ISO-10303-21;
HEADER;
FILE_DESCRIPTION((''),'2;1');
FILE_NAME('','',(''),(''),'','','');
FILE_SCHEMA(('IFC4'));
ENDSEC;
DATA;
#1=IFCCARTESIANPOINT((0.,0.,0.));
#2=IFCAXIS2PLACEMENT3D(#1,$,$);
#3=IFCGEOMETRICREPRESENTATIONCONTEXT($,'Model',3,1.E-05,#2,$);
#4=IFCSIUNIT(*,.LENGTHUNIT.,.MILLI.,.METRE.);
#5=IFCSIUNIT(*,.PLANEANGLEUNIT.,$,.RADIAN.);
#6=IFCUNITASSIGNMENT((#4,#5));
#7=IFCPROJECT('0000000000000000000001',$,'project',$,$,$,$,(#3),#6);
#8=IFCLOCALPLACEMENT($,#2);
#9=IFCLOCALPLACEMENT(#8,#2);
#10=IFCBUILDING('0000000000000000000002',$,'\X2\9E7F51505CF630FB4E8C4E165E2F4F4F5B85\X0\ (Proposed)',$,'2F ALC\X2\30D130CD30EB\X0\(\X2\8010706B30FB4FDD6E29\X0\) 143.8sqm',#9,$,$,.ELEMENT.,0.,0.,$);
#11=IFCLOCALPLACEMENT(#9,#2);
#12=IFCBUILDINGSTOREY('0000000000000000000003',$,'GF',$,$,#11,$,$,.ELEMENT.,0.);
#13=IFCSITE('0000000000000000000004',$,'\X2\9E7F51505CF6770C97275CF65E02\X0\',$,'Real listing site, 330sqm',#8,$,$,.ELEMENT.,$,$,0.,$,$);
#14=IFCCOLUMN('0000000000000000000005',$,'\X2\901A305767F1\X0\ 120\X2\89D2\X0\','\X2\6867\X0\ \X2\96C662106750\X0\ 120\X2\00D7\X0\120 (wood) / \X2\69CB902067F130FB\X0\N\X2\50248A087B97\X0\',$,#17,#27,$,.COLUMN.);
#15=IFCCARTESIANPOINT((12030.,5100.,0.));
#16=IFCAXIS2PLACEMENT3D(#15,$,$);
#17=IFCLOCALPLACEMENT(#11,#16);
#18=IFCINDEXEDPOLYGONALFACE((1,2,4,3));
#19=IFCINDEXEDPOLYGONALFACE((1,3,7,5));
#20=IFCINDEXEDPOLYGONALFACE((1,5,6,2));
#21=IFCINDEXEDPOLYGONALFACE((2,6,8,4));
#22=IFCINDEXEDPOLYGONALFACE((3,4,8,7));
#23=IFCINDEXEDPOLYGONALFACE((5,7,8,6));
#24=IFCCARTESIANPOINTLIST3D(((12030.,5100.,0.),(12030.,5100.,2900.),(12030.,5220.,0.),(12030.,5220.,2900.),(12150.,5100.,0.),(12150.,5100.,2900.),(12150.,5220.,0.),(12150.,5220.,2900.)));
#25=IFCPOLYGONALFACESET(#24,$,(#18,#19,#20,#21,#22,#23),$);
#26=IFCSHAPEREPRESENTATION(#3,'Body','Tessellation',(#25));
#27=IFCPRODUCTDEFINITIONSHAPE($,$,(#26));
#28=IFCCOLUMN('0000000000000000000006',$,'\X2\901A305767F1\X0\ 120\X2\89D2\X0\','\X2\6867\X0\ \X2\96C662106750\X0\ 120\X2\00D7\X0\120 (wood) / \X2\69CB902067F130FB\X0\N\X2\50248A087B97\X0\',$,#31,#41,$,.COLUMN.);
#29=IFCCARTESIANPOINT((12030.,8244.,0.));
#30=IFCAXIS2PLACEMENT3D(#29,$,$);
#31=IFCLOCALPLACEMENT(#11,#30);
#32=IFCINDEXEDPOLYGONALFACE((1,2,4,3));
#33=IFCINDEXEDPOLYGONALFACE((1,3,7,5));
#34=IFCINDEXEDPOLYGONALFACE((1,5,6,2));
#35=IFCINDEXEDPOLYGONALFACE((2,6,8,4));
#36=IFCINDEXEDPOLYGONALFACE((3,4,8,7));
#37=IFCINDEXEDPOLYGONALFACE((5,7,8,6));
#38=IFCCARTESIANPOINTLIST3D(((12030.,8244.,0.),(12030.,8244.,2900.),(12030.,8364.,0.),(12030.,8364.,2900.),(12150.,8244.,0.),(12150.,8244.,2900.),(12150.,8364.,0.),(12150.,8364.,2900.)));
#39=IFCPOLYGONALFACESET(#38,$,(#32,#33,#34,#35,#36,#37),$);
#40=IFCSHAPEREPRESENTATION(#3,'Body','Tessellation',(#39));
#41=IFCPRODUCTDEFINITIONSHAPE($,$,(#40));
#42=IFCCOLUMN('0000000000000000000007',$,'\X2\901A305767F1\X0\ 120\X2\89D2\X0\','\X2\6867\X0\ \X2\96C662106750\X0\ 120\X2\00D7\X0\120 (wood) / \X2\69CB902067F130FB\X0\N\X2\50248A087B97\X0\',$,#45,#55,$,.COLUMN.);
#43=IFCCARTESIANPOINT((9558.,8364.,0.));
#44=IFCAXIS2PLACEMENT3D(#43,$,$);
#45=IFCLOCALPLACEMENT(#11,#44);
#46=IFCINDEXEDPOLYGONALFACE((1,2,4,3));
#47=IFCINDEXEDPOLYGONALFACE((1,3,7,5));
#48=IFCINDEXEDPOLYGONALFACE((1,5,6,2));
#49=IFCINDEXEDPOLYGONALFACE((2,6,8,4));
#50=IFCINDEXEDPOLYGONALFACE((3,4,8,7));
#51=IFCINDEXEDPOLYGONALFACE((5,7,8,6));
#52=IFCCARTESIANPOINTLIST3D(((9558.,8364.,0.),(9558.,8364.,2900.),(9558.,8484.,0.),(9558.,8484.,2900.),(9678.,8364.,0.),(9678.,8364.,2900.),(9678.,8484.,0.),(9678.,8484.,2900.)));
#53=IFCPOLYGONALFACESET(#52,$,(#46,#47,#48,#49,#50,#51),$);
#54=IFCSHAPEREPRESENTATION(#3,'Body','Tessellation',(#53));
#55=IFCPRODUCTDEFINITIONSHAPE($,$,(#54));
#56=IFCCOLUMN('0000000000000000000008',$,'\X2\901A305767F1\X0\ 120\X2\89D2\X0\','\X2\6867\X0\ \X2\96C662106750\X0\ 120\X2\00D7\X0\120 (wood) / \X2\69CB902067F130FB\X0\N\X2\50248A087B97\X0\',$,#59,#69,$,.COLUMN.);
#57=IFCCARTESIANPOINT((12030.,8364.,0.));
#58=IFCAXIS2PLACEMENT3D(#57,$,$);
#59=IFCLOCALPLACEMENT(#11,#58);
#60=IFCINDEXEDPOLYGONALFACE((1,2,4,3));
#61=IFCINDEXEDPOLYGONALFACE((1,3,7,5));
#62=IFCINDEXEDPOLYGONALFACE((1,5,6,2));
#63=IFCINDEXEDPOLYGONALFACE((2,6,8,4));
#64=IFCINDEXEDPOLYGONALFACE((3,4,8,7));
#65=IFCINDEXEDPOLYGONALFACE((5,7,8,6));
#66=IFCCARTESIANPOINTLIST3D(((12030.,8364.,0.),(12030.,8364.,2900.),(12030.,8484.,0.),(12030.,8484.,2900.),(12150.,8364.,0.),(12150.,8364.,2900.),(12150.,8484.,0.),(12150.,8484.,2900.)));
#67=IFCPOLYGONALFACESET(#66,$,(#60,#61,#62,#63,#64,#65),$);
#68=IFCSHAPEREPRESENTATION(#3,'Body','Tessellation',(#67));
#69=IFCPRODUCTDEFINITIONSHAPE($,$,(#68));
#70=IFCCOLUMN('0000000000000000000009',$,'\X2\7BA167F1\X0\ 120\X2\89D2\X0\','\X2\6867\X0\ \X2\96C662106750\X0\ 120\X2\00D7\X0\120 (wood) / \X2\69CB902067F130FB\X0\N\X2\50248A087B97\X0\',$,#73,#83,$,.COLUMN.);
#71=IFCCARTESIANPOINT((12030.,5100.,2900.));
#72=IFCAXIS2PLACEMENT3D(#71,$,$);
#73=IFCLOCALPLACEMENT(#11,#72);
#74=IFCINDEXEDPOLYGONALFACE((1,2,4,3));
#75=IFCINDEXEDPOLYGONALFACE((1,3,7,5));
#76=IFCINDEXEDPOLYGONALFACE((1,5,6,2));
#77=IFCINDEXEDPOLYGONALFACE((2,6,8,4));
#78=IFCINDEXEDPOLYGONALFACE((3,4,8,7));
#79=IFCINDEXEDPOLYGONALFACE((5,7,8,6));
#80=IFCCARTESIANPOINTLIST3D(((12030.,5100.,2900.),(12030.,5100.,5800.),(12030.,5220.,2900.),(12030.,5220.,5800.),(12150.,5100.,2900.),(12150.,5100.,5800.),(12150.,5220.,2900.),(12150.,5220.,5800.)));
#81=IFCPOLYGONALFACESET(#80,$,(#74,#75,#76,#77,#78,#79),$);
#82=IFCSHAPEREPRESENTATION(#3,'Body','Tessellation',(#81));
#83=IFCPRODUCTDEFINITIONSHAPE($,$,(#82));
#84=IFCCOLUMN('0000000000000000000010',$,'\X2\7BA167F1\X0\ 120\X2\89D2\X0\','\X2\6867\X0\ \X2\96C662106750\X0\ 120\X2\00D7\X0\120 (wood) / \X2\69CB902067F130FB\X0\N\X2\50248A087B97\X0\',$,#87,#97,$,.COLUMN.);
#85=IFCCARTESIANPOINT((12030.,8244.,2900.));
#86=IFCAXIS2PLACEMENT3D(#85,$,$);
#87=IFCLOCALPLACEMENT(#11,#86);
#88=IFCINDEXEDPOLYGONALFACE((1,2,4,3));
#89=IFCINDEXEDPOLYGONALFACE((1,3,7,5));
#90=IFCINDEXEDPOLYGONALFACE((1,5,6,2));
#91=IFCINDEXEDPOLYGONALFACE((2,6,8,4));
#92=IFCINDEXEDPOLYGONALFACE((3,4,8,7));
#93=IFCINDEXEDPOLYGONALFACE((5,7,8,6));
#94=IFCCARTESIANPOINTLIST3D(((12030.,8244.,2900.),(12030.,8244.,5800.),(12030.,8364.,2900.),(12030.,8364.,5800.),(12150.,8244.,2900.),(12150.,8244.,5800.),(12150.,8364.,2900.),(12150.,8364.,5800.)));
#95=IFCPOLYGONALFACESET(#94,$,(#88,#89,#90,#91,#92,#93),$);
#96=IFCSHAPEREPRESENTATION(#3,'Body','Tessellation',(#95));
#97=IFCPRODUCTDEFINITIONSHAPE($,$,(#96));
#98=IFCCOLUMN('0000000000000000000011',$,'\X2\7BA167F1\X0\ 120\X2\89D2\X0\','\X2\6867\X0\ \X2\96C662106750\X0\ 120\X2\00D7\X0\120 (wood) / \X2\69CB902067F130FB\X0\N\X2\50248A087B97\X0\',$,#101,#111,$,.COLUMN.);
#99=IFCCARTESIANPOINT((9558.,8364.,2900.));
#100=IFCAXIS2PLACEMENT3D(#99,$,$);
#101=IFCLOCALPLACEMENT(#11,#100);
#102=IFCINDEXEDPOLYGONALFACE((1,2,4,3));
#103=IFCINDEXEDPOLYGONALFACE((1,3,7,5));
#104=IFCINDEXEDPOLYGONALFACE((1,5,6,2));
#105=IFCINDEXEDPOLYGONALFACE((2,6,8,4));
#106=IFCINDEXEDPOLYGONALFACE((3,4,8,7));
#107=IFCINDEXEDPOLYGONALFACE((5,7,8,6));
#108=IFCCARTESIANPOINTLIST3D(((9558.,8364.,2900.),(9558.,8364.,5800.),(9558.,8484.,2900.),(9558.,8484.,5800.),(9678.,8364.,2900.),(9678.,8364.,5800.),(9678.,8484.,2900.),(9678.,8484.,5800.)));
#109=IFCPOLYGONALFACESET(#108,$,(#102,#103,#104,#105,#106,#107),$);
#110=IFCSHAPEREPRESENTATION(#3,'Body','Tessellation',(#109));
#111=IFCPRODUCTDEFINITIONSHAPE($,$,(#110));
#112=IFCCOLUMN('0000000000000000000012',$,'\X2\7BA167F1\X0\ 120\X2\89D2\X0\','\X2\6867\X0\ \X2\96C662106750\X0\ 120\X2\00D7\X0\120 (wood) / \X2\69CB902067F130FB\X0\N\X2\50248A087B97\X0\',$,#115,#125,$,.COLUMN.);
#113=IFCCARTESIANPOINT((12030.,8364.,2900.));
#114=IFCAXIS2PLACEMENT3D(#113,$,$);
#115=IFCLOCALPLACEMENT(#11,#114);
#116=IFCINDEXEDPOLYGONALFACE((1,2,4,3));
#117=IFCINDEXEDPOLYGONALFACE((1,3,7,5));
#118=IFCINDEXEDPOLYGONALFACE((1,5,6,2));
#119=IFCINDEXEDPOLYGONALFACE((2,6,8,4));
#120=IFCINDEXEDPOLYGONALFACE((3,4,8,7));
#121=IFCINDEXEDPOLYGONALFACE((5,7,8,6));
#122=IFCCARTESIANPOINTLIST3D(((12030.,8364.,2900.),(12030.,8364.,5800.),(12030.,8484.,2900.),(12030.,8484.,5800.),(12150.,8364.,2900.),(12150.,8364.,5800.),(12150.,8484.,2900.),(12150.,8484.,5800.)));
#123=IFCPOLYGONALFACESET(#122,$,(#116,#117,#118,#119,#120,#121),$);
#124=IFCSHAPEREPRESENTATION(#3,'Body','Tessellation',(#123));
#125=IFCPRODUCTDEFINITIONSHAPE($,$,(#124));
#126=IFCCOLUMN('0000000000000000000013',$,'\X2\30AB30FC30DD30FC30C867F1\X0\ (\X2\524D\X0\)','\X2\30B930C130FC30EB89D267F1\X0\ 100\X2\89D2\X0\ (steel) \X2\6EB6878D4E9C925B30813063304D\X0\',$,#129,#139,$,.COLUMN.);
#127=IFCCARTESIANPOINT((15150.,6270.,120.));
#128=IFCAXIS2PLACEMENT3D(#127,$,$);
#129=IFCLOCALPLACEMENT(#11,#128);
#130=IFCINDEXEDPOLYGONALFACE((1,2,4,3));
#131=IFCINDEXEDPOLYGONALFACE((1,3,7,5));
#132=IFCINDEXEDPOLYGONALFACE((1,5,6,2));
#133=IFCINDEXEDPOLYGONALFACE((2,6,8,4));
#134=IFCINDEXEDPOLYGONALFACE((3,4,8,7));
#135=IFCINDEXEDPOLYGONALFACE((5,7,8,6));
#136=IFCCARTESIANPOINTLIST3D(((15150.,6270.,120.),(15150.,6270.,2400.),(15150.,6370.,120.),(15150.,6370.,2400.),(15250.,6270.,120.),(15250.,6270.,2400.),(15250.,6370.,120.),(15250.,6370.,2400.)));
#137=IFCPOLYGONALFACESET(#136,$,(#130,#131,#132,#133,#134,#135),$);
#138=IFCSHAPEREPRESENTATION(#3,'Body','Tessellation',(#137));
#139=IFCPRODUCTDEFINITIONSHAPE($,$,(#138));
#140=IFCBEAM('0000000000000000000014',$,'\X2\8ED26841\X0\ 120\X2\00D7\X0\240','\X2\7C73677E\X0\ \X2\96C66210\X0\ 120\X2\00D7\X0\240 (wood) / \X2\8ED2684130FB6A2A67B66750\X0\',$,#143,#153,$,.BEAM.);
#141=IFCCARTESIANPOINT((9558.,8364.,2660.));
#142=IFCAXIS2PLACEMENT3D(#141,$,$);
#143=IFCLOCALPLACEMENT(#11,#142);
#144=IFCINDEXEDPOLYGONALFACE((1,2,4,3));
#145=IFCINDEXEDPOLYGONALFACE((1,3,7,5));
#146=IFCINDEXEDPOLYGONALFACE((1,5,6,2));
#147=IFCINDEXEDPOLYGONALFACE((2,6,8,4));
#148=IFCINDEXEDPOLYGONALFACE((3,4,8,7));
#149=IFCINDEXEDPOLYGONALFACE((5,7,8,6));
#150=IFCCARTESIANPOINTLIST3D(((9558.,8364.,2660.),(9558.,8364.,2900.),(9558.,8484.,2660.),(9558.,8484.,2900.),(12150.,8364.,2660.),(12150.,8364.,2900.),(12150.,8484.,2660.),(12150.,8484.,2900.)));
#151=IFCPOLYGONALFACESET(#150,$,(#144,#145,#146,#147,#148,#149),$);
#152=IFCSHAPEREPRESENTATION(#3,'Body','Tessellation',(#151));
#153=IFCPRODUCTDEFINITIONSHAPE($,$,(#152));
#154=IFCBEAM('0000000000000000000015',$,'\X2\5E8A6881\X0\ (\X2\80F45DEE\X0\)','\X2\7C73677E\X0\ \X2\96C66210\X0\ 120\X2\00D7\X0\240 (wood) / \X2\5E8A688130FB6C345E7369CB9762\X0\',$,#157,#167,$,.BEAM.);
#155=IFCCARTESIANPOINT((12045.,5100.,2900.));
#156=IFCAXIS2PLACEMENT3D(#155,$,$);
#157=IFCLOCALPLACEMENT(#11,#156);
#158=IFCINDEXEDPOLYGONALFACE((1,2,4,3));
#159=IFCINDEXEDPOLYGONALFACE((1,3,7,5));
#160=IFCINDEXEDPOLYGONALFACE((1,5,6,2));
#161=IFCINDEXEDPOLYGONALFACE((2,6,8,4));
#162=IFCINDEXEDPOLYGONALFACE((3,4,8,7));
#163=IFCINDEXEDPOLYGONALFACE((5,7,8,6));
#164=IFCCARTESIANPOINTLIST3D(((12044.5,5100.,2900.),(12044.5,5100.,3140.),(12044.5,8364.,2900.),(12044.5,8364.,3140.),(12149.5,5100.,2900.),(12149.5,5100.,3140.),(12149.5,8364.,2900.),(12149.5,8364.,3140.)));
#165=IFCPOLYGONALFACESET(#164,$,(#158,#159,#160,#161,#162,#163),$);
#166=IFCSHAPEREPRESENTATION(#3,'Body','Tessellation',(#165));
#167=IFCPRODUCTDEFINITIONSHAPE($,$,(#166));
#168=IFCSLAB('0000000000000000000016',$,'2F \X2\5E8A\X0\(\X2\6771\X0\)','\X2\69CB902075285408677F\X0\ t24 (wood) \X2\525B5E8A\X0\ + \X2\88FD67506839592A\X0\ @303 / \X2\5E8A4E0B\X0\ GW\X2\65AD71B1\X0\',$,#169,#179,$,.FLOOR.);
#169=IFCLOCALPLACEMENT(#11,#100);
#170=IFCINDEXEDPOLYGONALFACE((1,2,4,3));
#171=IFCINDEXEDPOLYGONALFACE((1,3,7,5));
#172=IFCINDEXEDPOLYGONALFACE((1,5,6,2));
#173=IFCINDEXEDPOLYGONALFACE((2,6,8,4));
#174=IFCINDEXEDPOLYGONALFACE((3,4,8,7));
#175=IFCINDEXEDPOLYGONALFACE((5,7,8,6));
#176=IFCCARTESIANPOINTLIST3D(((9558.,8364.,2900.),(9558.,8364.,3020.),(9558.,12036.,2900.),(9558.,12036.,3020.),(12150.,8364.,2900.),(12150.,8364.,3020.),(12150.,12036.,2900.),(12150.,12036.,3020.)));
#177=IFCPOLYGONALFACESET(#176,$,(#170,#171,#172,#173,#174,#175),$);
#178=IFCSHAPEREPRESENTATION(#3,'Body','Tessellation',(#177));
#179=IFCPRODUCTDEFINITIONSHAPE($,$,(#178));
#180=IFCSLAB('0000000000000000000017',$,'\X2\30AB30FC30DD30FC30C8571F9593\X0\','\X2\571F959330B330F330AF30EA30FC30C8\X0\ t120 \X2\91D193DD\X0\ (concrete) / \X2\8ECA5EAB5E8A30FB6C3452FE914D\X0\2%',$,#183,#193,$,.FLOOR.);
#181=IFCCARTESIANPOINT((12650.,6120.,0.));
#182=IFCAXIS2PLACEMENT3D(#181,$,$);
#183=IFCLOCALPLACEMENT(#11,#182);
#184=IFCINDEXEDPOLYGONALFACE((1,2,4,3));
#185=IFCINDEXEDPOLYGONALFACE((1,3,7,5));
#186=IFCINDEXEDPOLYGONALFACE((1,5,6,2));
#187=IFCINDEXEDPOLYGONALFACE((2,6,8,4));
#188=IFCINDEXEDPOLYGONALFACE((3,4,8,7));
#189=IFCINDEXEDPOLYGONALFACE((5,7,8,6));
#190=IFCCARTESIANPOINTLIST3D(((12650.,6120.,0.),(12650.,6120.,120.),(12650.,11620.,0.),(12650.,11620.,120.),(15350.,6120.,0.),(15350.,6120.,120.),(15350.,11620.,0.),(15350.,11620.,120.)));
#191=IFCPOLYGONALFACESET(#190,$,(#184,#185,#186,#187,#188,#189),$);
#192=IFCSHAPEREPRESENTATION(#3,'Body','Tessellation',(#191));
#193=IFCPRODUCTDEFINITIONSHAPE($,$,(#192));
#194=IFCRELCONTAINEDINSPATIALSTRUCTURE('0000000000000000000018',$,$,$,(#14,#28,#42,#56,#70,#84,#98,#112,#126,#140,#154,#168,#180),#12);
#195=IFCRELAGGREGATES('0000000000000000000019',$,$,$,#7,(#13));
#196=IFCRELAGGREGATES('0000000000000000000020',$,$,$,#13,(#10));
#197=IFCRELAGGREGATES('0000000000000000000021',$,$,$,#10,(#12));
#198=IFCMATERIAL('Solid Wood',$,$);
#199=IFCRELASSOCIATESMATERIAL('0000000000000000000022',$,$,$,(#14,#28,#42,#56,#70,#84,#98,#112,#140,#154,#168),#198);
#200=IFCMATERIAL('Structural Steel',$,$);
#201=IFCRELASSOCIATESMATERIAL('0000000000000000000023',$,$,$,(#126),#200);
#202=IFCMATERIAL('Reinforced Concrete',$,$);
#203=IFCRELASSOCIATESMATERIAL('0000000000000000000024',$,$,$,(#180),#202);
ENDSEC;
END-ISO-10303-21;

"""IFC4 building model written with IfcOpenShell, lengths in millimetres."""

from ifc_helpers import new_model, si_unit, frame, frame_2d, origin, place, context, project, spatial, rectangle, extrude, material, element, save


model = new_model("IFC4")

# Units and contexts
model_context = context("Model", 3, precision=1e-05, world=origin())
ifc_project = project(units=[si_unit("LENGTHUNIT", "METRE", prefix="MILLI"), si_unit("PLANEANGLEUNIT", "RADIAN")], contexts=[model_context])

# Site, building, storey
site_placement = place(None, origin())
site = spatial("IfcSite", under=ifc_project, at=site_placement, Name="鹿児島県霧島市", ObjectType="Real listing site, 330sqm", CompositionType="ELEMENT", RefElevation=0.0)
building_placement = place(site_placement, origin())
building = spatial("IfcBuilding", under=site, at=building_placement, Name="鹿児島・二世帯住宅 (Proposed)", ObjectType="2F ALCパネル(耐火・保温) 143.8sqm", CompositionType="ELEMENT", ElevationOfRefHeight=0.0, ElevationOfTerrain=0.0)
storey_placement = place(building_placement, origin())
storey = spatial("IfcBuildingStorey", under=building, at=storey_placement, Name="GF", CompositionType="ELEMENT", Elevation=0.0)

# Columns
ifc_material_1 = material(Name="Solid Wood")
column_1_placement = place(storey_placement, frame((12030.0, 5100.0, 0.0)))
element("IfcColumn", 1, at=column_1_placement, inside=storey, material=ifc_material_1, Name="通し柱 120角", Description="桧 集成材 120×120 (wood) / 構造柱・N値計算", PredefinedType="COLUMN", context=model_context, shape_type="SweptSolid", body=[
    extrude(rectangle(XDim=120.0, YDim=120.0, at=frame_2d((60.0, 60.0))), frame((12030.0, 5100.0, 0.0)), (0.0, 0.0, 1.0), 2900.0),
])
column_2_placement = place(storey_placement, frame((12030.0, 8244.0, 0.0)))
element("IfcColumn", 2, at=column_2_placement, inside=storey, material=ifc_material_1, Name="通し柱 120角", Description="桧 集成材 120×120 (wood) / 構造柱・N値計算", PredefinedType="COLUMN", context=model_context, shape_type="SweptSolid", body=[
    extrude(rectangle(XDim=120.0, YDim=120.0, at=frame_2d((60.0, 60.0))), frame((12030.0, 8244.0, 0.0)), (0.0, 0.0, 1.0), 2900.0),
])
column_3_placement = place(storey_placement, frame((9558.0, 8364.0, 0.0)))
element("IfcColumn", 3, at=column_3_placement, inside=storey, material=ifc_material_1, Name="通し柱 120角", Description="桧 集成材 120×120 (wood) / 構造柱・N値計算", PredefinedType="COLUMN", context=model_context, shape_type="SweptSolid", body=[
    extrude(rectangle(XDim=120.0, YDim=120.0, at=frame_2d((60.0, 60.0))), frame((9558.0, 8364.0, 0.0)), (0.0, 0.0, 1.0), 2900.0),
])
column_4_placement = place(storey_placement, frame((12030.0, 8364.0, 0.0)))
element("IfcColumn", 4, at=column_4_placement, inside=storey, material=ifc_material_1, Name="通し柱 120角", Description="桧 集成材 120×120 (wood) / 構造柱・N値計算", PredefinedType="COLUMN", context=model_context, shape_type="SweptSolid", body=[
    extrude(rectangle(XDim=120.0, YDim=120.0, at=frame_2d((60.0, 60.0))), frame((12030.0, 8364.0, 0.0)), (0.0, 0.0, 1.0), 2900.0),
])
column_5_placement = place(storey_placement, frame((12030.0, 5100.0, 2900.0)))
element("IfcColumn", 5, at=column_5_placement, inside=storey, material=ifc_material_1, Name="管柱 120角", Description="桧 集成材 120×120 (wood) / 構造柱・N値計算", PredefinedType="COLUMN", context=model_context, shape_type="SweptSolid", body=[
    extrude(rectangle(XDim=120.0, YDim=120.0, at=frame_2d((60.0, 60.0))), frame((12030.0, 5100.0, 2900.0)), (0.0, 0.0, 1.0), 2900.0),
])
column_6_placement = place(storey_placement, frame((12030.0, 8244.0, 2900.0)))
element("IfcColumn", 6, at=column_6_placement, inside=storey, material=ifc_material_1, Name="管柱 120角", Description="桧 集成材 120×120 (wood) / 構造柱・N値計算", PredefinedType="COLUMN", context=model_context, shape_type="SweptSolid", body=[
    extrude(rectangle(XDim=120.0, YDim=120.0, at=frame_2d((60.0, 60.0))), frame((12030.0, 8244.0, 2900.0)), (0.0, 0.0, 1.0), 2900.0),
])
column_7_placement = place(storey_placement, frame((9558.0, 8364.0, 2900.0)))
element("IfcColumn", 7, at=column_7_placement, inside=storey, material=ifc_material_1, Name="管柱 120角", Description="桧 集成材 120×120 (wood) / 構造柱・N値計算", PredefinedType="COLUMN", context=model_context, shape_type="SweptSolid", body=[
    extrude(rectangle(XDim=120.0, YDim=120.0, at=frame_2d((60.0, 60.0))), frame((9558.0, 8364.0, 2900.0)), (0.0, 0.0, 1.0), 2900.0),
])
column_8_placement = place(storey_placement, frame((12030.0, 8364.0, 2900.0)))
element("IfcColumn", 8, at=column_8_placement, inside=storey, material=ifc_material_1, Name="管柱 120角", Description="桧 集成材 120×120 (wood) / 構造柱・N値計算", PredefinedType="COLUMN", context=model_context, shape_type="SweptSolid", body=[
    extrude(rectangle(XDim=120.0, YDim=120.0, at=frame_2d((60.0, 60.0))), frame((12030.0, 8364.0, 2900.0)), (0.0, 0.0, 1.0), 2900.0),
])
ifc_material_2 = material(Name="Structural Steel")
column_9_placement = place(storey_placement, frame((15150.0, 6270.0, 120.0)))
element("IfcColumn", 9, at=column_9_placement, inside=storey, material=ifc_material_2, Name="カーポート柱 (前)", Description="スチール角柱 100角 (steel) 溶融亜鉛めっき", PredefinedType="COLUMN", context=model_context, shape_type="SweptSolid", body=[
    extrude(rectangle(XDim=100.0, YDim=100.0, at=frame_2d((50.0, 50.0))), frame((15150.0, 6270.0, 120.0)), (0.0, 0.0, 1.0), 2280.0),
])

# Beams
beam_1_placement = place(storey_placement, frame((9558.0, 8364.0, 2660.0)))
element("IfcBeam", 10, at=beam_1_placement, inside=storey, material=ifc_material_1, Name="軒桁 120×240", Description="米松 集成 120×240 (wood) / 軒桁・横架材", PredefinedType="BEAM", context=model_context, shape_type="SweptSolid", body=[
    extrude(rectangle(XDim=2592.0, YDim=120.0, at=frame_2d((1296.0, 60.0))), frame((9558.0, 8364.0, 2660.0)), (0.0, 0.0, 1.0), 240.0),
])
beam_2_placement = place(storey_placement, frame((12045.0, 5100.0, 2900.0)))
element("IfcBeam", 11, at=beam_2_placement, inside=storey, material=ifc_material_1, Name="床梁 (胴差)", Description="米松 集成 120×240 (wood) / 床梁・水平構面", PredefinedType="BEAM", context=model_context, shape_type="SweptSolid", body=[
    extrude(rectangle(XDim=105.0, YDim=3264.0, at=frame_2d((52.0, 1632.0))), frame((12045.0, 5100.0, 2900.0)), (0.0, 0.0, 1.0), 240.0),
])

# Slabs
slab_1_placement = place(storey_placement, frame((9558.0, 8364.0, 2900.0)))
element("IfcSlab", 12, at=slab_1_placement, inside=storey, material=ifc_material_1, Name="2F 床(東)", Description="構造用合板 t24 (wood) 剛床 + 製材根太 @303 / 床下 GW断熱", PredefinedType="FLOOR", context=model_context, shape_type="SweptSolid", body=[
    extrude(rectangle(XDim=2592.0, YDim=3672.0, at=frame_2d((1296.0, 1836.0))), frame((9558.0, 8364.0, 2900.0)), (0.0, 0.0, 1.0), 120.0),
])
ifc_material_3 = material(Name="Reinforced Concrete")
slab_2_placement = place(storey_placement, frame((12650.0, 6120.0, 0.0)))
element("IfcSlab", 13, at=slab_2_placement, inside=storey, material=ifc_material_3, Name="カーポート土間", Description="土間コンクリート t120 金鏝 (concrete) / 車庫床・水勾配2%", PredefinedType="FLOOR", context=model_context, shape_type="SweptSolid", body=[
    extrude(rectangle(XDim=2700.0, YDim=5500.0, at=frame_2d((1350.0, 2750.0))), frame((12650.0, 6120.0, 0.0)), (0.0, 0.0, 1.0), 120.0),
])

save(model, "model.ifc")
